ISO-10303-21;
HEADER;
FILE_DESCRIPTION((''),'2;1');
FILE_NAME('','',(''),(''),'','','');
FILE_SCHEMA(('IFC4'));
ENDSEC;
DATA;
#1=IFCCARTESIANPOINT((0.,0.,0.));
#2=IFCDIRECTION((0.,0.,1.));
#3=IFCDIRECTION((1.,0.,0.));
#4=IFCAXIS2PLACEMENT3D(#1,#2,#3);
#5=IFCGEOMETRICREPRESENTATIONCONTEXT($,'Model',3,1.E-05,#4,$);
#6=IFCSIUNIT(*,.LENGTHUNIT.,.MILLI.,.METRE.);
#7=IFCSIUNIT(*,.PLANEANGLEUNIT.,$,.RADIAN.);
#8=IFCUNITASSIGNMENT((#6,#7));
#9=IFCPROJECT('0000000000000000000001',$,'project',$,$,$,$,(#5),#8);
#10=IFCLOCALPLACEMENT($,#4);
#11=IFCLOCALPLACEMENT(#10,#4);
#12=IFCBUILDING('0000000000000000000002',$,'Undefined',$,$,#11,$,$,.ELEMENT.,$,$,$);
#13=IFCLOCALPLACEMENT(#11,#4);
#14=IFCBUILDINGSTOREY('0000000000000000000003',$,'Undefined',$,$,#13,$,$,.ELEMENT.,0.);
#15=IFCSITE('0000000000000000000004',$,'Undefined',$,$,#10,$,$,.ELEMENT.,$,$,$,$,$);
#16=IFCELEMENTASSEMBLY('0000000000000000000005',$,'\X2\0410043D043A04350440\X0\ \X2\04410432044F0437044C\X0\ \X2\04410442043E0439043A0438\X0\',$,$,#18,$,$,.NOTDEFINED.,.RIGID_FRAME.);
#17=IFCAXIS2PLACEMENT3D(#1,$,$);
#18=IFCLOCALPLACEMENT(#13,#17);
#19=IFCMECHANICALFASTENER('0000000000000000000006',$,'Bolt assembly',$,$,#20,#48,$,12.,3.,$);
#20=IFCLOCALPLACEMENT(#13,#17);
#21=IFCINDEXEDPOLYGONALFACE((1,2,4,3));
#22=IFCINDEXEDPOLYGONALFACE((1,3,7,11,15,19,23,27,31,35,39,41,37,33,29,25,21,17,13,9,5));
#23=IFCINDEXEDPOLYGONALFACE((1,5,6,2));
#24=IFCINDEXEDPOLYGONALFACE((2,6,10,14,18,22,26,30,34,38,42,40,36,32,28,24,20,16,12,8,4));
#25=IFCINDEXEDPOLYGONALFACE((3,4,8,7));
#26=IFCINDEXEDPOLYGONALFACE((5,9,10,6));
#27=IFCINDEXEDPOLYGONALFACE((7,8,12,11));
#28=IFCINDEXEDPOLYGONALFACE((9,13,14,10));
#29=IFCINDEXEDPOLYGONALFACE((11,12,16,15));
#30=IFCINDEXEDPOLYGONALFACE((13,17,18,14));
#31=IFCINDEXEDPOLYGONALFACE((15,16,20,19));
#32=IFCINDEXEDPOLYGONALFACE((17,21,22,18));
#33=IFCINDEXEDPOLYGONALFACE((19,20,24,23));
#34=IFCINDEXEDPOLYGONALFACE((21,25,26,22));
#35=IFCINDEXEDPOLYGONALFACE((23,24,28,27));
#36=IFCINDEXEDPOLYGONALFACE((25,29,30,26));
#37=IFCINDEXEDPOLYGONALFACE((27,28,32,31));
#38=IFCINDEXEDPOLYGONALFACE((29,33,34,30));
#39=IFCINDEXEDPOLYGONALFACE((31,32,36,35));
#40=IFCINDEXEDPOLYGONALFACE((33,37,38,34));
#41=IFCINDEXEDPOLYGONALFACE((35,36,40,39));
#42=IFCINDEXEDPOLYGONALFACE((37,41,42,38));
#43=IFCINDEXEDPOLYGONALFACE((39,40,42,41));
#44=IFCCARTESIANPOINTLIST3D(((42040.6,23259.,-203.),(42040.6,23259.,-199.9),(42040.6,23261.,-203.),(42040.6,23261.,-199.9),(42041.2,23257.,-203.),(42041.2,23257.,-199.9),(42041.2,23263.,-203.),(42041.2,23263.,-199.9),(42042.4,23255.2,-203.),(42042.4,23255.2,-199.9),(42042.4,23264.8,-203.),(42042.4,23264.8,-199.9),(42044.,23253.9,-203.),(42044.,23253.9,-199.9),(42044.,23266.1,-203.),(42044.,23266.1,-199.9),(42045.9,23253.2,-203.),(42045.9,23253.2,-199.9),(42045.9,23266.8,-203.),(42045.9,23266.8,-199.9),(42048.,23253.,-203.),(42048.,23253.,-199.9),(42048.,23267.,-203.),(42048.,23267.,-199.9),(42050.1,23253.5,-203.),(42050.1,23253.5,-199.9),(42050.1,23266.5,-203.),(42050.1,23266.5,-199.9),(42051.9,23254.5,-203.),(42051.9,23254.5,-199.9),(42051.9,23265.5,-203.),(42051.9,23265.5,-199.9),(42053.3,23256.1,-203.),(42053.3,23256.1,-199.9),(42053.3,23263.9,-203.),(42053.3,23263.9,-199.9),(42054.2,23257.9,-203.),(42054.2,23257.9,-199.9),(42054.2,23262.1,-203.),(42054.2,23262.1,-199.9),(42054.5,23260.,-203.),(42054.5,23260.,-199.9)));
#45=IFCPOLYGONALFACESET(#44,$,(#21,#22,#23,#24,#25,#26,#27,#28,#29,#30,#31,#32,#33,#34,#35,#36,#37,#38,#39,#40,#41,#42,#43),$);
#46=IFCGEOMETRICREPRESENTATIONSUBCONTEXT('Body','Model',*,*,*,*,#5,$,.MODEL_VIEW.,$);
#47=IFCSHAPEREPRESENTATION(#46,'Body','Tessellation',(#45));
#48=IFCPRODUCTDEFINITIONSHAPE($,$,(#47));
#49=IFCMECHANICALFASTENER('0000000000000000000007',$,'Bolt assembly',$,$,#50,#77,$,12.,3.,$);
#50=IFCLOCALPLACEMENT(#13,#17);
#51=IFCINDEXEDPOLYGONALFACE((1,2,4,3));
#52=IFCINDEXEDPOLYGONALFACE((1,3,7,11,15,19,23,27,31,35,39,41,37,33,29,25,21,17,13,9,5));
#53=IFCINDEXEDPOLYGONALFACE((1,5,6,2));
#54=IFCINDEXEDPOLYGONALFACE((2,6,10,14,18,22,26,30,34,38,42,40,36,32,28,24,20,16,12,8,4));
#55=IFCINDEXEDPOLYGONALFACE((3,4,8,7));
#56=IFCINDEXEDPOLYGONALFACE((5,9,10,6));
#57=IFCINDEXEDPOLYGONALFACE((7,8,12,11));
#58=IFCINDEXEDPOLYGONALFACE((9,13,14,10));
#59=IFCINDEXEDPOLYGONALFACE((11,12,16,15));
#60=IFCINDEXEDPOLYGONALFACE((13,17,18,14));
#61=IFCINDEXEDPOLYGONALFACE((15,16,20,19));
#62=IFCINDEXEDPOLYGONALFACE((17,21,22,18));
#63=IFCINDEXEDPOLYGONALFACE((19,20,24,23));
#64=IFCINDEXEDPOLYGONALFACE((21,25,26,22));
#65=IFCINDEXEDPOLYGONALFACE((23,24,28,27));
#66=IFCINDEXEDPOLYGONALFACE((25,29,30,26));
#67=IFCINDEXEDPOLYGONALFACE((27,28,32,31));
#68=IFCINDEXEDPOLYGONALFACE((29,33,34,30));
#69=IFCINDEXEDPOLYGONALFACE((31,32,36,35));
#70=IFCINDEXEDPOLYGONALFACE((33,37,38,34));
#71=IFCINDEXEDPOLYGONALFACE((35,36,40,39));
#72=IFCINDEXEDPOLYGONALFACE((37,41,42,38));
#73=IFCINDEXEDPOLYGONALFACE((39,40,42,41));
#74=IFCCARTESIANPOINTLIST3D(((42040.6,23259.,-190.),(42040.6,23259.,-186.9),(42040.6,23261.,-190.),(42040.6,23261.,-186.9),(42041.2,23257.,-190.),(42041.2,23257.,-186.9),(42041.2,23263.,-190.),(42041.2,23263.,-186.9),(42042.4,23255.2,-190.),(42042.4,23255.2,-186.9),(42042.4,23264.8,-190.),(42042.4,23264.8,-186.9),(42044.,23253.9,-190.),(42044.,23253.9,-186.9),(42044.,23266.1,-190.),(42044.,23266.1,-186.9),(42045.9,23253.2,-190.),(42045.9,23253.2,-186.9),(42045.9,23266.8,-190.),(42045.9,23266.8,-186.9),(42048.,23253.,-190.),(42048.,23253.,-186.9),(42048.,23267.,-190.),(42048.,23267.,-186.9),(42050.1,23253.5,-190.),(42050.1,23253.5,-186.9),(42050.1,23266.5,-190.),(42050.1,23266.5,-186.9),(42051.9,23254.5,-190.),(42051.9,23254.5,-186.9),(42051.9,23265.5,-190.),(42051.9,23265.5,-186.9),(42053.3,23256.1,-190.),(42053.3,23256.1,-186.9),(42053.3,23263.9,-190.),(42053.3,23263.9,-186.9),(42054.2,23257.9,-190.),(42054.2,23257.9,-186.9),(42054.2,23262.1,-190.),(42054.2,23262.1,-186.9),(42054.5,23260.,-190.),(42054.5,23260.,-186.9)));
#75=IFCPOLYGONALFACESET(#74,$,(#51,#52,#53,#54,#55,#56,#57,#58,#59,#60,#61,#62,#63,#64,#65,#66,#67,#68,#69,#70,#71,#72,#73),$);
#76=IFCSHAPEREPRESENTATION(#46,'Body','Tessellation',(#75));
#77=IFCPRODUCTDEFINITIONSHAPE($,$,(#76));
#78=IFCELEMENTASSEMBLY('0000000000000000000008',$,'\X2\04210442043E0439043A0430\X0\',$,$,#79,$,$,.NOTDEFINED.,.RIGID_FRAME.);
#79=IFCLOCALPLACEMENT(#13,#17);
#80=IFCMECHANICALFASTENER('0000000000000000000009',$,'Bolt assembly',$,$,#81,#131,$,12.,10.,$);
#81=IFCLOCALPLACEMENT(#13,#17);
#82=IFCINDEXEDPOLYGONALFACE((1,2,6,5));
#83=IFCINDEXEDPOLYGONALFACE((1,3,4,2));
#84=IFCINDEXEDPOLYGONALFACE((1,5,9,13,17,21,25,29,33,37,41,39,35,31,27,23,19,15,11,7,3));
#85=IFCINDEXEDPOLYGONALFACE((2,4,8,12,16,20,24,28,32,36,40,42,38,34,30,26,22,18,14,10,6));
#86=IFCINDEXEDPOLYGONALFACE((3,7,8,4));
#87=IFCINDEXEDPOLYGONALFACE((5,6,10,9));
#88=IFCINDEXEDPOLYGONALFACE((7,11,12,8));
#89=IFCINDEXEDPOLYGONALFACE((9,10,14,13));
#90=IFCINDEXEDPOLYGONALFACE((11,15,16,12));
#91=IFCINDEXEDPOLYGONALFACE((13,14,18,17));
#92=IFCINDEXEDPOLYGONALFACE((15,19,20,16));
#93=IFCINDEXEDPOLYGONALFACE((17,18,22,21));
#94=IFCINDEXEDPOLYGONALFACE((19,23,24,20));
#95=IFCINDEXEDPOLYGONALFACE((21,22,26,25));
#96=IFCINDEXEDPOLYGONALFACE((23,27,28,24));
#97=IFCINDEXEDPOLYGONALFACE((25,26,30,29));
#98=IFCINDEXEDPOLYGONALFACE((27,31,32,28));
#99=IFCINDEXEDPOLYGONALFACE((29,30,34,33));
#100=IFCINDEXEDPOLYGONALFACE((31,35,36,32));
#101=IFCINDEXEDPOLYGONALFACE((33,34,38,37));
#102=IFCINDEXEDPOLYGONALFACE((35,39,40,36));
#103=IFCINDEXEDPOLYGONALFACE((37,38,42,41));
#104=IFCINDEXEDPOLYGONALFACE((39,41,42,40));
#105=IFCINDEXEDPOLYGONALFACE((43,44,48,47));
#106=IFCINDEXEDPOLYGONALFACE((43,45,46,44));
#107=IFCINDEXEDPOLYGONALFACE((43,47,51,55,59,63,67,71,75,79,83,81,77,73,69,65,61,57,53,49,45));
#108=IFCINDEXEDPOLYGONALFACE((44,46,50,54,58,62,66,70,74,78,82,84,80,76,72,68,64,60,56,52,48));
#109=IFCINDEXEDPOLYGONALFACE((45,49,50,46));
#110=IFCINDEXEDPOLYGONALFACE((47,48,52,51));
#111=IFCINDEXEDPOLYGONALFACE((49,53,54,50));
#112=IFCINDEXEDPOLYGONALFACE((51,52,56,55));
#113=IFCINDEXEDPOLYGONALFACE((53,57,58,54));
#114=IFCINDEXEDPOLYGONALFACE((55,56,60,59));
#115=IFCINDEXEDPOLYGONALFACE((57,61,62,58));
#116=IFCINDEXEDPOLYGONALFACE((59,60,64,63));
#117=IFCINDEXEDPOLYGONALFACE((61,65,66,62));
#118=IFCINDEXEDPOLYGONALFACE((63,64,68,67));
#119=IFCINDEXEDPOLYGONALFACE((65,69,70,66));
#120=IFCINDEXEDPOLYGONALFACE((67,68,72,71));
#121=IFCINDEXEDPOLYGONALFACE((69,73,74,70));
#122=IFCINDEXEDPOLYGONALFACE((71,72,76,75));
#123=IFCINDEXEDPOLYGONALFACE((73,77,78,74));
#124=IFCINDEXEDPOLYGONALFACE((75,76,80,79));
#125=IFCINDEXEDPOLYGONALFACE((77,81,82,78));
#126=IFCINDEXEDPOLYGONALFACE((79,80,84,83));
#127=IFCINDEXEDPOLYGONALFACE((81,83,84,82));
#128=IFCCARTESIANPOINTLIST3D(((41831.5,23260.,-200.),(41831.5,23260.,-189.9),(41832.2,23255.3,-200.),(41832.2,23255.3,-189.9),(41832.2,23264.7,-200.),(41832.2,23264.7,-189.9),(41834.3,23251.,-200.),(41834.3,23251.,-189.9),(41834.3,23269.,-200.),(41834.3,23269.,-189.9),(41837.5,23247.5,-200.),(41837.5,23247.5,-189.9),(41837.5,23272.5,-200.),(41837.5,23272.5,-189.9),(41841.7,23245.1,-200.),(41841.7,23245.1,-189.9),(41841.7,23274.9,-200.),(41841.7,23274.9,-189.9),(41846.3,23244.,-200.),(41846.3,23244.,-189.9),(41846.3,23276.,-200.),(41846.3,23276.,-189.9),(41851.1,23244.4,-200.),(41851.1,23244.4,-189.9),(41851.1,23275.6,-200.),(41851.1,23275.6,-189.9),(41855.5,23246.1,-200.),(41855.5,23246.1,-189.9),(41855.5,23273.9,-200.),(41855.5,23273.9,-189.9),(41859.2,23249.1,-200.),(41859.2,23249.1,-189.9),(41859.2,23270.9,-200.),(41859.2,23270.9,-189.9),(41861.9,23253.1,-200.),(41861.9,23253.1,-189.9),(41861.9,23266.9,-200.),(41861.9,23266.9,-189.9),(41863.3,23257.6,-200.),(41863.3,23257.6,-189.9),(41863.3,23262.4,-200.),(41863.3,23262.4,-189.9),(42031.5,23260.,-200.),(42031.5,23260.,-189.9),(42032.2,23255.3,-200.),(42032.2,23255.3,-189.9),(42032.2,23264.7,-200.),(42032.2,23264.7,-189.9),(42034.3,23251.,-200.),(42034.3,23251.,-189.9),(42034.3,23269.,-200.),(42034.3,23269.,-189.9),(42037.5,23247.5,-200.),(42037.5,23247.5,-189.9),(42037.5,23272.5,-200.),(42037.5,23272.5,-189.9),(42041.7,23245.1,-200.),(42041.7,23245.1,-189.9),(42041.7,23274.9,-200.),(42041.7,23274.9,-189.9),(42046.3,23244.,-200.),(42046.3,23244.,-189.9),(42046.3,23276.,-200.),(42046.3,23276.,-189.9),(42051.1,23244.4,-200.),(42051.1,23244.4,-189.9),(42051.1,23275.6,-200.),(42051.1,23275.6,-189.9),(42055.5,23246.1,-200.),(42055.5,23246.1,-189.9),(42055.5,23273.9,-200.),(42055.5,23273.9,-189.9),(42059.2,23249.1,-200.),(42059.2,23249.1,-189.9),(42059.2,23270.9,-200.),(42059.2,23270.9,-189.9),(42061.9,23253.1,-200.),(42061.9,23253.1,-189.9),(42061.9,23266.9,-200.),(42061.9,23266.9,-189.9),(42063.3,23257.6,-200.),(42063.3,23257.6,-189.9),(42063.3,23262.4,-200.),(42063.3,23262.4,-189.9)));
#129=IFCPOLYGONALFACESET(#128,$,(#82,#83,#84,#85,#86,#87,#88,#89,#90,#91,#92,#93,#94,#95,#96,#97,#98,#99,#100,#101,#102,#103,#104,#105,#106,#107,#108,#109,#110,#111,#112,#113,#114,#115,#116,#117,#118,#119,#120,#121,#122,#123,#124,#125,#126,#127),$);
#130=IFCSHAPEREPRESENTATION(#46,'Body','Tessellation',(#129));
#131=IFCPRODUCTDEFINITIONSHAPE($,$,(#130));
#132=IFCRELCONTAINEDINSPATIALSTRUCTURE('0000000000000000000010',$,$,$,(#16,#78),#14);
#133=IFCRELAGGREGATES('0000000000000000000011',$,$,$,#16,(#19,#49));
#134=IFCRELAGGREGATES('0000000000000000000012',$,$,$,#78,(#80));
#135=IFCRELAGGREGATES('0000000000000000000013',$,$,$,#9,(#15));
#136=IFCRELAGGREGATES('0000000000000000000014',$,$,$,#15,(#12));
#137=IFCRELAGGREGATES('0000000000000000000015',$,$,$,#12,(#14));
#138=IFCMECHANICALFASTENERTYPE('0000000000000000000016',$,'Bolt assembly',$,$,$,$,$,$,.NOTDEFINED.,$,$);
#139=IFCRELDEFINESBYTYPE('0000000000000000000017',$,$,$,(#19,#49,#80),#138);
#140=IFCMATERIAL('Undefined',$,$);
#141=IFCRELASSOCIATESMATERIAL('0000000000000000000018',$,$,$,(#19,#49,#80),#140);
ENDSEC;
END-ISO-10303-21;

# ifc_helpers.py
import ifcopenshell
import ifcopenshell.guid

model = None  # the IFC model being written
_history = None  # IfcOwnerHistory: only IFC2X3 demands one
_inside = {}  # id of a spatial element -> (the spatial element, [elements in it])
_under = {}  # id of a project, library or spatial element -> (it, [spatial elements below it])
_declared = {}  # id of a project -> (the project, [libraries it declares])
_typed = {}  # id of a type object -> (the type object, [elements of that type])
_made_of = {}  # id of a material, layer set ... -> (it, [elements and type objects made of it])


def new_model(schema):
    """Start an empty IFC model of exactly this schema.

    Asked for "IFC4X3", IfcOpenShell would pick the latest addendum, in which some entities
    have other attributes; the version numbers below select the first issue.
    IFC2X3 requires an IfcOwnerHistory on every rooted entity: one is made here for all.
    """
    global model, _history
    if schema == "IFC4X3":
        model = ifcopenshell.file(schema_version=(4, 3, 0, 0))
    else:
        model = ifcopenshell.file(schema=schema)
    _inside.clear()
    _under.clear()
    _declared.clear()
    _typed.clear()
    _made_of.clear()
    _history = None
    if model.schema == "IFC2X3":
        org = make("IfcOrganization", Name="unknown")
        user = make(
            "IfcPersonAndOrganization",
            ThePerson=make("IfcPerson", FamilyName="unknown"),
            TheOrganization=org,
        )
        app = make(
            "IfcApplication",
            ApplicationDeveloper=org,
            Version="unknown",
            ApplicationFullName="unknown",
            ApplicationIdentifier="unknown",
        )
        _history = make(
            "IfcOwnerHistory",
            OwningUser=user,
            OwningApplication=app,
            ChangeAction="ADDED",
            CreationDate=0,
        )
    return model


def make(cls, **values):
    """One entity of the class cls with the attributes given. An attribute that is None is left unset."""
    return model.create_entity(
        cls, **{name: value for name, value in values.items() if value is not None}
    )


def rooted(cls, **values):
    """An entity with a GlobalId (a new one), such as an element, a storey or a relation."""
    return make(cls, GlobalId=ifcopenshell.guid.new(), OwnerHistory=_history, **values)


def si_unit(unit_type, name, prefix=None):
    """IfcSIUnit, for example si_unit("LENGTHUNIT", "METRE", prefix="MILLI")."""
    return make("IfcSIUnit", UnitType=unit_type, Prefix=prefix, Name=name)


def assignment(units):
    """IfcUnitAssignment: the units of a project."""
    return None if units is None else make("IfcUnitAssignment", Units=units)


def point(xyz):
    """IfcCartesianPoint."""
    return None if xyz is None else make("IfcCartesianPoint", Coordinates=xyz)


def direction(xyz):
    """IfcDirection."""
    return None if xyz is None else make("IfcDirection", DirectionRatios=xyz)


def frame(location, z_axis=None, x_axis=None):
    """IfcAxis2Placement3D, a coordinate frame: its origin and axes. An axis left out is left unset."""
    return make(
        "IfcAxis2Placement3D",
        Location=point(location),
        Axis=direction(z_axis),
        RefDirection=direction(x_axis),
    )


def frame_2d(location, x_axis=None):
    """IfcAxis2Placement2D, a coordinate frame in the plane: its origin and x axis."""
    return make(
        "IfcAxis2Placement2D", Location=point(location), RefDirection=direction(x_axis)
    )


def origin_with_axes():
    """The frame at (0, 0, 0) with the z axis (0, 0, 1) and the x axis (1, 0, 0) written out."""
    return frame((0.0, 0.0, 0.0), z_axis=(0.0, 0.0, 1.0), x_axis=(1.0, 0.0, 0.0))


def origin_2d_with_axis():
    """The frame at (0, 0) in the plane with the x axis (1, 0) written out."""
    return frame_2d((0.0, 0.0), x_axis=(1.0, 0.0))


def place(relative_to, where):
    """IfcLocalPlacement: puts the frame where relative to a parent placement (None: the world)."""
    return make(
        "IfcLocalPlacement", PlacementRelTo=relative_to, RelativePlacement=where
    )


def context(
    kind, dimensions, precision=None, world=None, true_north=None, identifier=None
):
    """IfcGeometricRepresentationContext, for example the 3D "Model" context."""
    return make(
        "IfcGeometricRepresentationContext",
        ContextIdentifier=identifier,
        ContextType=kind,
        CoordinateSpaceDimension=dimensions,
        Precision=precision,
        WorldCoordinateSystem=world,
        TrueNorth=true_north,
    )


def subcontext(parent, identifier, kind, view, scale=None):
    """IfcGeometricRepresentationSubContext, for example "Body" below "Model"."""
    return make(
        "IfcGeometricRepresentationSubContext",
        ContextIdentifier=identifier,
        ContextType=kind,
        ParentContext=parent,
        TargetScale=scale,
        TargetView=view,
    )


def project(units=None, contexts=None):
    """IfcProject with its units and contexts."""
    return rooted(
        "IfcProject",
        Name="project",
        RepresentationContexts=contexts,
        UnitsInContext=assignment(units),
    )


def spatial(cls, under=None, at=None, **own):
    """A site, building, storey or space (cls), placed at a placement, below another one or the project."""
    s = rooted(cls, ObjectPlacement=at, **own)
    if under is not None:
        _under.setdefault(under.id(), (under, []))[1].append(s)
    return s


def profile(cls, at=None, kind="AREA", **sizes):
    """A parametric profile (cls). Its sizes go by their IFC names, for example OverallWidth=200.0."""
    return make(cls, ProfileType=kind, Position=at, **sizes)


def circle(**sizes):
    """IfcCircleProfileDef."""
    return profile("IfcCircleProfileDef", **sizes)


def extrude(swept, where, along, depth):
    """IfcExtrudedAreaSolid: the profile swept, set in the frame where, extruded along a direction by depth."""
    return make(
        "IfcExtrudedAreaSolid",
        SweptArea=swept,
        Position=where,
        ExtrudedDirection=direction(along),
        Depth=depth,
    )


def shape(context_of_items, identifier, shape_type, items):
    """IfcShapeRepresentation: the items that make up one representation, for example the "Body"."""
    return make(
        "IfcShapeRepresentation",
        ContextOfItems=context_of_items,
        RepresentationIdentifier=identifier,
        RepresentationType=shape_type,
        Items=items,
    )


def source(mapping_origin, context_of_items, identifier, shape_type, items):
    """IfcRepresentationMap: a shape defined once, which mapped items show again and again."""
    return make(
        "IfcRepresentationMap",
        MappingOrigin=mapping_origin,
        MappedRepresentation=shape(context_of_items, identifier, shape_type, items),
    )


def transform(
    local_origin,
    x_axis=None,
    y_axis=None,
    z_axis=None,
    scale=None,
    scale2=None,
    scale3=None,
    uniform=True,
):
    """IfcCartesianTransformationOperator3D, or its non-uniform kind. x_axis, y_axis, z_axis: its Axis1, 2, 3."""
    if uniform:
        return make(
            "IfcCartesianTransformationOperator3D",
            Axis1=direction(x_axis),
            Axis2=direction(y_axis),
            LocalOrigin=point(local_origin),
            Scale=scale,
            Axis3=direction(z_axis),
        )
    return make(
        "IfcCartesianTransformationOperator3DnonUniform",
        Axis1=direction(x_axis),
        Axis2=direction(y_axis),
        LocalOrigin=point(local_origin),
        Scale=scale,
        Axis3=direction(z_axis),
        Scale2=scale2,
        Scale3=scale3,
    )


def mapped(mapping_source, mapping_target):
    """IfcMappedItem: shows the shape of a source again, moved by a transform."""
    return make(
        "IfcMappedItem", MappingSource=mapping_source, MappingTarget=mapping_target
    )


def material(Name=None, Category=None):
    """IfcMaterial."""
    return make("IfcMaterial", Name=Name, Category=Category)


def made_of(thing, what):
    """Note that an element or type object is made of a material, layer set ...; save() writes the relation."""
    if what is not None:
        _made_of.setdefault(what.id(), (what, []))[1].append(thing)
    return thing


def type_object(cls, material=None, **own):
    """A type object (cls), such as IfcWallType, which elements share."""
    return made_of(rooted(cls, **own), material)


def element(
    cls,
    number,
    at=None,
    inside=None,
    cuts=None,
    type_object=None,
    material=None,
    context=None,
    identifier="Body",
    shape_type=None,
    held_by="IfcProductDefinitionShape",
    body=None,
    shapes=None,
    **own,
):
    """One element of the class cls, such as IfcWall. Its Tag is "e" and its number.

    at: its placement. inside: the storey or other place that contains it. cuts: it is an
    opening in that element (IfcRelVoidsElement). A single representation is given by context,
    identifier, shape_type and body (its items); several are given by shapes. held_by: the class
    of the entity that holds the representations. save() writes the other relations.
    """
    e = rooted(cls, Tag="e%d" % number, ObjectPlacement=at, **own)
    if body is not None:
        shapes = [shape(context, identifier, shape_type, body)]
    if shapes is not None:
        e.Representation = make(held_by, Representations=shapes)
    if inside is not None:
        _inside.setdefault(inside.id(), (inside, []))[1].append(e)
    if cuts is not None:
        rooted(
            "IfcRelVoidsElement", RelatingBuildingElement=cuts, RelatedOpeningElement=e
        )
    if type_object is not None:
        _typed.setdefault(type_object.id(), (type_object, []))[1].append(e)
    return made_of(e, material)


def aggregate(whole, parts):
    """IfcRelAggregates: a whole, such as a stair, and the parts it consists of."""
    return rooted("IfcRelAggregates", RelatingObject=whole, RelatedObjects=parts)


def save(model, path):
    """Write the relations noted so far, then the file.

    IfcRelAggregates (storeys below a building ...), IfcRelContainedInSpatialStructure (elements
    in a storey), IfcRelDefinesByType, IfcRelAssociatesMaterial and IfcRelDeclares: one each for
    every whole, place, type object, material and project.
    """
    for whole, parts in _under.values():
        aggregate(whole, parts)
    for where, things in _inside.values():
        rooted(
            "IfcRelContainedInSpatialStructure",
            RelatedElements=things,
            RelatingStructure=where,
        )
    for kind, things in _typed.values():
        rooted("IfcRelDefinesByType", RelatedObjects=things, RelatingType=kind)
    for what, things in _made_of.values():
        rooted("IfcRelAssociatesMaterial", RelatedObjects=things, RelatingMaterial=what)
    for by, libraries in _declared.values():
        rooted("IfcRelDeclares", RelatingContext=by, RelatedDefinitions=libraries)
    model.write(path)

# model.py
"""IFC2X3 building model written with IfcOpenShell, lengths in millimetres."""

from ifc_helpers import new_model, si_unit, frame, origin_with_axes, origin_2d_with_axis, place, context, subcontext, project, spatial, circle, extrude, source, transform, mapped, material, type_object, element, aggregate, save


model = new_model("IFC2X3")

# Units and contexts
model_context = context("Model", 3, precision=1e-05, world=origin_with_axes())
body_context = subcontext(model_context, "Body", "Model", "MODEL_VIEW")
ifc_project = project(units=[si_unit("LENGTHUNIT", "METRE", prefix="MILLI"), si_unit("PLANEANGLEUNIT", "RADIAN")], contexts=[model_context])

# Site, building, storey
site_placement = place(None, origin_with_axes())
site = spatial("IfcSite", under=ifc_project, at=site_placement, Name="Undefined", CompositionType="ELEMENT")
building_placement = place(site_placement, origin_with_axes())
building = spatial("IfcBuilding", under=site, at=building_placement, Name="Undefined", CompositionType="ELEMENT")
storey_placement = place(building_placement, origin_with_axes())
storey = spatial("IfcBuildingStorey", under=building, at=storey_placement, Name="Undefined", CompositionType="ELEMENT", Elevation=0.0)

# Element assembly
assembly_1_placement = place(storey_placement, origin_with_axes())
assembly_1 = element("IfcElementAssembly", 1, at=assembly_1_placement, inside=storey, Name="Анкер связь стойки", AssemblyPlace="NOTDEFINED", PredefinedType="RIGID_FRAME")

# Mechanical fasteners
ifc_material_1 = material(Name="Undefined")
mechanical_fastener_type = type_object("IfcMechanicalFastenerType", Name="Bolt assembly")
shared_shape_1 = source(origin_with_axes(), body_context, "Body", "SweptSolid", [
    extrude(circle(Radius=7.0, at=origin_2d_with_axis()), frame((0.0, -3.0, 0.0), z_axis=(0.0, 1.0, 0.0), x_axis=(1.0, 0.0, 0.0)), (0.0, 0.0, 1.0), 3.1),
])
mechanical_fastener_1_placement = place(assembly_1_placement, frame((42047.5, 23260.0, -200.0), z_axis=(0.0, -1.0, 0.0), x_axis=(1.0, 0.0, 0.0)))
mechanical_fastener_1 = element("IfcMechanicalFastener", 2, at=mechanical_fastener_1_placement, type_object=mechanical_fastener_type, material=ifc_material_1, Name="Bolt assembly", NominalDiameter=12.0, NominalLength=3.0, context=body_context, shape_type="MappedRepresentation", body=[
    mapped(shared_shape_1, transform((0.0, 0.0, 0.0))),
])
mechanical_fastener_2_placement = place(assembly_1_placement, frame((42047.5, 23260.0, -187.0), z_axis=(0.0, -1.0, 0.0), x_axis=(1.0, 0.0, 0.0)))
mechanical_fastener_2 = element("IfcMechanicalFastener", 3, at=mechanical_fastener_2_placement, type_object=mechanical_fastener_type, material=ifc_material_1, Name="Bolt assembly", NominalDiameter=12.0, NominalLength=3.0, context=body_context, shape_type="MappedRepresentation", body=[
    mapped(shared_shape_1, transform((0.0, 0.0, 0.0))),
])
aggregate(assembly_1, [mechanical_fastener_1, mechanical_fastener_2])

# Element assembly, mechanical fastener
assembly_2_placement = place(storey_placement, origin_with_axes())
assembly_2 = element("IfcElementAssembly", 4, at=assembly_2_placement, inside=storey, Name="Стойка", AssemblyPlace="NOTDEFINED", PredefinedType="RIGID_FRAME")
shared_shape_2 = source(origin_with_axes(), body_context, "Body", "SweptSolid", [
    extrude(circle(Radius=16.0, at=origin_2d_with_axis()), frame((0.0, -10.0, 0.0), z_axis=(0.0, 1.0, 0.0), x_axis=(1.0, 0.0, 0.0)), (0.0, 0.0, 1.0), 10.1),
])
mechanical_fastener_3_placement = place(assembly_2_placement, frame((41997.5, 23260.0, -190.0), z_axis=(0.0, 1.0, 0.0), x_axis=(-1.0, 0.0, 0.0)))
mechanical_fastener_3 = element("IfcMechanicalFastener", 5, at=mechanical_fastener_3_placement, type_object=mechanical_fastener_type, material=ifc_material_1, Name="Bolt assembly", NominalDiameter=12.0, NominalLength=10.0, context=body_context, shape_type="MappedRepresentation", body=[
    mapped(shared_shape_2, transform((-50.0, 0.0, 0.0))),
    mapped(shared_shape_2, transform((150.0, 0.0, 0.0))),
])
aggregate(assembly_2, [mechanical_fastener_3])

save(model, "model.ifc")
